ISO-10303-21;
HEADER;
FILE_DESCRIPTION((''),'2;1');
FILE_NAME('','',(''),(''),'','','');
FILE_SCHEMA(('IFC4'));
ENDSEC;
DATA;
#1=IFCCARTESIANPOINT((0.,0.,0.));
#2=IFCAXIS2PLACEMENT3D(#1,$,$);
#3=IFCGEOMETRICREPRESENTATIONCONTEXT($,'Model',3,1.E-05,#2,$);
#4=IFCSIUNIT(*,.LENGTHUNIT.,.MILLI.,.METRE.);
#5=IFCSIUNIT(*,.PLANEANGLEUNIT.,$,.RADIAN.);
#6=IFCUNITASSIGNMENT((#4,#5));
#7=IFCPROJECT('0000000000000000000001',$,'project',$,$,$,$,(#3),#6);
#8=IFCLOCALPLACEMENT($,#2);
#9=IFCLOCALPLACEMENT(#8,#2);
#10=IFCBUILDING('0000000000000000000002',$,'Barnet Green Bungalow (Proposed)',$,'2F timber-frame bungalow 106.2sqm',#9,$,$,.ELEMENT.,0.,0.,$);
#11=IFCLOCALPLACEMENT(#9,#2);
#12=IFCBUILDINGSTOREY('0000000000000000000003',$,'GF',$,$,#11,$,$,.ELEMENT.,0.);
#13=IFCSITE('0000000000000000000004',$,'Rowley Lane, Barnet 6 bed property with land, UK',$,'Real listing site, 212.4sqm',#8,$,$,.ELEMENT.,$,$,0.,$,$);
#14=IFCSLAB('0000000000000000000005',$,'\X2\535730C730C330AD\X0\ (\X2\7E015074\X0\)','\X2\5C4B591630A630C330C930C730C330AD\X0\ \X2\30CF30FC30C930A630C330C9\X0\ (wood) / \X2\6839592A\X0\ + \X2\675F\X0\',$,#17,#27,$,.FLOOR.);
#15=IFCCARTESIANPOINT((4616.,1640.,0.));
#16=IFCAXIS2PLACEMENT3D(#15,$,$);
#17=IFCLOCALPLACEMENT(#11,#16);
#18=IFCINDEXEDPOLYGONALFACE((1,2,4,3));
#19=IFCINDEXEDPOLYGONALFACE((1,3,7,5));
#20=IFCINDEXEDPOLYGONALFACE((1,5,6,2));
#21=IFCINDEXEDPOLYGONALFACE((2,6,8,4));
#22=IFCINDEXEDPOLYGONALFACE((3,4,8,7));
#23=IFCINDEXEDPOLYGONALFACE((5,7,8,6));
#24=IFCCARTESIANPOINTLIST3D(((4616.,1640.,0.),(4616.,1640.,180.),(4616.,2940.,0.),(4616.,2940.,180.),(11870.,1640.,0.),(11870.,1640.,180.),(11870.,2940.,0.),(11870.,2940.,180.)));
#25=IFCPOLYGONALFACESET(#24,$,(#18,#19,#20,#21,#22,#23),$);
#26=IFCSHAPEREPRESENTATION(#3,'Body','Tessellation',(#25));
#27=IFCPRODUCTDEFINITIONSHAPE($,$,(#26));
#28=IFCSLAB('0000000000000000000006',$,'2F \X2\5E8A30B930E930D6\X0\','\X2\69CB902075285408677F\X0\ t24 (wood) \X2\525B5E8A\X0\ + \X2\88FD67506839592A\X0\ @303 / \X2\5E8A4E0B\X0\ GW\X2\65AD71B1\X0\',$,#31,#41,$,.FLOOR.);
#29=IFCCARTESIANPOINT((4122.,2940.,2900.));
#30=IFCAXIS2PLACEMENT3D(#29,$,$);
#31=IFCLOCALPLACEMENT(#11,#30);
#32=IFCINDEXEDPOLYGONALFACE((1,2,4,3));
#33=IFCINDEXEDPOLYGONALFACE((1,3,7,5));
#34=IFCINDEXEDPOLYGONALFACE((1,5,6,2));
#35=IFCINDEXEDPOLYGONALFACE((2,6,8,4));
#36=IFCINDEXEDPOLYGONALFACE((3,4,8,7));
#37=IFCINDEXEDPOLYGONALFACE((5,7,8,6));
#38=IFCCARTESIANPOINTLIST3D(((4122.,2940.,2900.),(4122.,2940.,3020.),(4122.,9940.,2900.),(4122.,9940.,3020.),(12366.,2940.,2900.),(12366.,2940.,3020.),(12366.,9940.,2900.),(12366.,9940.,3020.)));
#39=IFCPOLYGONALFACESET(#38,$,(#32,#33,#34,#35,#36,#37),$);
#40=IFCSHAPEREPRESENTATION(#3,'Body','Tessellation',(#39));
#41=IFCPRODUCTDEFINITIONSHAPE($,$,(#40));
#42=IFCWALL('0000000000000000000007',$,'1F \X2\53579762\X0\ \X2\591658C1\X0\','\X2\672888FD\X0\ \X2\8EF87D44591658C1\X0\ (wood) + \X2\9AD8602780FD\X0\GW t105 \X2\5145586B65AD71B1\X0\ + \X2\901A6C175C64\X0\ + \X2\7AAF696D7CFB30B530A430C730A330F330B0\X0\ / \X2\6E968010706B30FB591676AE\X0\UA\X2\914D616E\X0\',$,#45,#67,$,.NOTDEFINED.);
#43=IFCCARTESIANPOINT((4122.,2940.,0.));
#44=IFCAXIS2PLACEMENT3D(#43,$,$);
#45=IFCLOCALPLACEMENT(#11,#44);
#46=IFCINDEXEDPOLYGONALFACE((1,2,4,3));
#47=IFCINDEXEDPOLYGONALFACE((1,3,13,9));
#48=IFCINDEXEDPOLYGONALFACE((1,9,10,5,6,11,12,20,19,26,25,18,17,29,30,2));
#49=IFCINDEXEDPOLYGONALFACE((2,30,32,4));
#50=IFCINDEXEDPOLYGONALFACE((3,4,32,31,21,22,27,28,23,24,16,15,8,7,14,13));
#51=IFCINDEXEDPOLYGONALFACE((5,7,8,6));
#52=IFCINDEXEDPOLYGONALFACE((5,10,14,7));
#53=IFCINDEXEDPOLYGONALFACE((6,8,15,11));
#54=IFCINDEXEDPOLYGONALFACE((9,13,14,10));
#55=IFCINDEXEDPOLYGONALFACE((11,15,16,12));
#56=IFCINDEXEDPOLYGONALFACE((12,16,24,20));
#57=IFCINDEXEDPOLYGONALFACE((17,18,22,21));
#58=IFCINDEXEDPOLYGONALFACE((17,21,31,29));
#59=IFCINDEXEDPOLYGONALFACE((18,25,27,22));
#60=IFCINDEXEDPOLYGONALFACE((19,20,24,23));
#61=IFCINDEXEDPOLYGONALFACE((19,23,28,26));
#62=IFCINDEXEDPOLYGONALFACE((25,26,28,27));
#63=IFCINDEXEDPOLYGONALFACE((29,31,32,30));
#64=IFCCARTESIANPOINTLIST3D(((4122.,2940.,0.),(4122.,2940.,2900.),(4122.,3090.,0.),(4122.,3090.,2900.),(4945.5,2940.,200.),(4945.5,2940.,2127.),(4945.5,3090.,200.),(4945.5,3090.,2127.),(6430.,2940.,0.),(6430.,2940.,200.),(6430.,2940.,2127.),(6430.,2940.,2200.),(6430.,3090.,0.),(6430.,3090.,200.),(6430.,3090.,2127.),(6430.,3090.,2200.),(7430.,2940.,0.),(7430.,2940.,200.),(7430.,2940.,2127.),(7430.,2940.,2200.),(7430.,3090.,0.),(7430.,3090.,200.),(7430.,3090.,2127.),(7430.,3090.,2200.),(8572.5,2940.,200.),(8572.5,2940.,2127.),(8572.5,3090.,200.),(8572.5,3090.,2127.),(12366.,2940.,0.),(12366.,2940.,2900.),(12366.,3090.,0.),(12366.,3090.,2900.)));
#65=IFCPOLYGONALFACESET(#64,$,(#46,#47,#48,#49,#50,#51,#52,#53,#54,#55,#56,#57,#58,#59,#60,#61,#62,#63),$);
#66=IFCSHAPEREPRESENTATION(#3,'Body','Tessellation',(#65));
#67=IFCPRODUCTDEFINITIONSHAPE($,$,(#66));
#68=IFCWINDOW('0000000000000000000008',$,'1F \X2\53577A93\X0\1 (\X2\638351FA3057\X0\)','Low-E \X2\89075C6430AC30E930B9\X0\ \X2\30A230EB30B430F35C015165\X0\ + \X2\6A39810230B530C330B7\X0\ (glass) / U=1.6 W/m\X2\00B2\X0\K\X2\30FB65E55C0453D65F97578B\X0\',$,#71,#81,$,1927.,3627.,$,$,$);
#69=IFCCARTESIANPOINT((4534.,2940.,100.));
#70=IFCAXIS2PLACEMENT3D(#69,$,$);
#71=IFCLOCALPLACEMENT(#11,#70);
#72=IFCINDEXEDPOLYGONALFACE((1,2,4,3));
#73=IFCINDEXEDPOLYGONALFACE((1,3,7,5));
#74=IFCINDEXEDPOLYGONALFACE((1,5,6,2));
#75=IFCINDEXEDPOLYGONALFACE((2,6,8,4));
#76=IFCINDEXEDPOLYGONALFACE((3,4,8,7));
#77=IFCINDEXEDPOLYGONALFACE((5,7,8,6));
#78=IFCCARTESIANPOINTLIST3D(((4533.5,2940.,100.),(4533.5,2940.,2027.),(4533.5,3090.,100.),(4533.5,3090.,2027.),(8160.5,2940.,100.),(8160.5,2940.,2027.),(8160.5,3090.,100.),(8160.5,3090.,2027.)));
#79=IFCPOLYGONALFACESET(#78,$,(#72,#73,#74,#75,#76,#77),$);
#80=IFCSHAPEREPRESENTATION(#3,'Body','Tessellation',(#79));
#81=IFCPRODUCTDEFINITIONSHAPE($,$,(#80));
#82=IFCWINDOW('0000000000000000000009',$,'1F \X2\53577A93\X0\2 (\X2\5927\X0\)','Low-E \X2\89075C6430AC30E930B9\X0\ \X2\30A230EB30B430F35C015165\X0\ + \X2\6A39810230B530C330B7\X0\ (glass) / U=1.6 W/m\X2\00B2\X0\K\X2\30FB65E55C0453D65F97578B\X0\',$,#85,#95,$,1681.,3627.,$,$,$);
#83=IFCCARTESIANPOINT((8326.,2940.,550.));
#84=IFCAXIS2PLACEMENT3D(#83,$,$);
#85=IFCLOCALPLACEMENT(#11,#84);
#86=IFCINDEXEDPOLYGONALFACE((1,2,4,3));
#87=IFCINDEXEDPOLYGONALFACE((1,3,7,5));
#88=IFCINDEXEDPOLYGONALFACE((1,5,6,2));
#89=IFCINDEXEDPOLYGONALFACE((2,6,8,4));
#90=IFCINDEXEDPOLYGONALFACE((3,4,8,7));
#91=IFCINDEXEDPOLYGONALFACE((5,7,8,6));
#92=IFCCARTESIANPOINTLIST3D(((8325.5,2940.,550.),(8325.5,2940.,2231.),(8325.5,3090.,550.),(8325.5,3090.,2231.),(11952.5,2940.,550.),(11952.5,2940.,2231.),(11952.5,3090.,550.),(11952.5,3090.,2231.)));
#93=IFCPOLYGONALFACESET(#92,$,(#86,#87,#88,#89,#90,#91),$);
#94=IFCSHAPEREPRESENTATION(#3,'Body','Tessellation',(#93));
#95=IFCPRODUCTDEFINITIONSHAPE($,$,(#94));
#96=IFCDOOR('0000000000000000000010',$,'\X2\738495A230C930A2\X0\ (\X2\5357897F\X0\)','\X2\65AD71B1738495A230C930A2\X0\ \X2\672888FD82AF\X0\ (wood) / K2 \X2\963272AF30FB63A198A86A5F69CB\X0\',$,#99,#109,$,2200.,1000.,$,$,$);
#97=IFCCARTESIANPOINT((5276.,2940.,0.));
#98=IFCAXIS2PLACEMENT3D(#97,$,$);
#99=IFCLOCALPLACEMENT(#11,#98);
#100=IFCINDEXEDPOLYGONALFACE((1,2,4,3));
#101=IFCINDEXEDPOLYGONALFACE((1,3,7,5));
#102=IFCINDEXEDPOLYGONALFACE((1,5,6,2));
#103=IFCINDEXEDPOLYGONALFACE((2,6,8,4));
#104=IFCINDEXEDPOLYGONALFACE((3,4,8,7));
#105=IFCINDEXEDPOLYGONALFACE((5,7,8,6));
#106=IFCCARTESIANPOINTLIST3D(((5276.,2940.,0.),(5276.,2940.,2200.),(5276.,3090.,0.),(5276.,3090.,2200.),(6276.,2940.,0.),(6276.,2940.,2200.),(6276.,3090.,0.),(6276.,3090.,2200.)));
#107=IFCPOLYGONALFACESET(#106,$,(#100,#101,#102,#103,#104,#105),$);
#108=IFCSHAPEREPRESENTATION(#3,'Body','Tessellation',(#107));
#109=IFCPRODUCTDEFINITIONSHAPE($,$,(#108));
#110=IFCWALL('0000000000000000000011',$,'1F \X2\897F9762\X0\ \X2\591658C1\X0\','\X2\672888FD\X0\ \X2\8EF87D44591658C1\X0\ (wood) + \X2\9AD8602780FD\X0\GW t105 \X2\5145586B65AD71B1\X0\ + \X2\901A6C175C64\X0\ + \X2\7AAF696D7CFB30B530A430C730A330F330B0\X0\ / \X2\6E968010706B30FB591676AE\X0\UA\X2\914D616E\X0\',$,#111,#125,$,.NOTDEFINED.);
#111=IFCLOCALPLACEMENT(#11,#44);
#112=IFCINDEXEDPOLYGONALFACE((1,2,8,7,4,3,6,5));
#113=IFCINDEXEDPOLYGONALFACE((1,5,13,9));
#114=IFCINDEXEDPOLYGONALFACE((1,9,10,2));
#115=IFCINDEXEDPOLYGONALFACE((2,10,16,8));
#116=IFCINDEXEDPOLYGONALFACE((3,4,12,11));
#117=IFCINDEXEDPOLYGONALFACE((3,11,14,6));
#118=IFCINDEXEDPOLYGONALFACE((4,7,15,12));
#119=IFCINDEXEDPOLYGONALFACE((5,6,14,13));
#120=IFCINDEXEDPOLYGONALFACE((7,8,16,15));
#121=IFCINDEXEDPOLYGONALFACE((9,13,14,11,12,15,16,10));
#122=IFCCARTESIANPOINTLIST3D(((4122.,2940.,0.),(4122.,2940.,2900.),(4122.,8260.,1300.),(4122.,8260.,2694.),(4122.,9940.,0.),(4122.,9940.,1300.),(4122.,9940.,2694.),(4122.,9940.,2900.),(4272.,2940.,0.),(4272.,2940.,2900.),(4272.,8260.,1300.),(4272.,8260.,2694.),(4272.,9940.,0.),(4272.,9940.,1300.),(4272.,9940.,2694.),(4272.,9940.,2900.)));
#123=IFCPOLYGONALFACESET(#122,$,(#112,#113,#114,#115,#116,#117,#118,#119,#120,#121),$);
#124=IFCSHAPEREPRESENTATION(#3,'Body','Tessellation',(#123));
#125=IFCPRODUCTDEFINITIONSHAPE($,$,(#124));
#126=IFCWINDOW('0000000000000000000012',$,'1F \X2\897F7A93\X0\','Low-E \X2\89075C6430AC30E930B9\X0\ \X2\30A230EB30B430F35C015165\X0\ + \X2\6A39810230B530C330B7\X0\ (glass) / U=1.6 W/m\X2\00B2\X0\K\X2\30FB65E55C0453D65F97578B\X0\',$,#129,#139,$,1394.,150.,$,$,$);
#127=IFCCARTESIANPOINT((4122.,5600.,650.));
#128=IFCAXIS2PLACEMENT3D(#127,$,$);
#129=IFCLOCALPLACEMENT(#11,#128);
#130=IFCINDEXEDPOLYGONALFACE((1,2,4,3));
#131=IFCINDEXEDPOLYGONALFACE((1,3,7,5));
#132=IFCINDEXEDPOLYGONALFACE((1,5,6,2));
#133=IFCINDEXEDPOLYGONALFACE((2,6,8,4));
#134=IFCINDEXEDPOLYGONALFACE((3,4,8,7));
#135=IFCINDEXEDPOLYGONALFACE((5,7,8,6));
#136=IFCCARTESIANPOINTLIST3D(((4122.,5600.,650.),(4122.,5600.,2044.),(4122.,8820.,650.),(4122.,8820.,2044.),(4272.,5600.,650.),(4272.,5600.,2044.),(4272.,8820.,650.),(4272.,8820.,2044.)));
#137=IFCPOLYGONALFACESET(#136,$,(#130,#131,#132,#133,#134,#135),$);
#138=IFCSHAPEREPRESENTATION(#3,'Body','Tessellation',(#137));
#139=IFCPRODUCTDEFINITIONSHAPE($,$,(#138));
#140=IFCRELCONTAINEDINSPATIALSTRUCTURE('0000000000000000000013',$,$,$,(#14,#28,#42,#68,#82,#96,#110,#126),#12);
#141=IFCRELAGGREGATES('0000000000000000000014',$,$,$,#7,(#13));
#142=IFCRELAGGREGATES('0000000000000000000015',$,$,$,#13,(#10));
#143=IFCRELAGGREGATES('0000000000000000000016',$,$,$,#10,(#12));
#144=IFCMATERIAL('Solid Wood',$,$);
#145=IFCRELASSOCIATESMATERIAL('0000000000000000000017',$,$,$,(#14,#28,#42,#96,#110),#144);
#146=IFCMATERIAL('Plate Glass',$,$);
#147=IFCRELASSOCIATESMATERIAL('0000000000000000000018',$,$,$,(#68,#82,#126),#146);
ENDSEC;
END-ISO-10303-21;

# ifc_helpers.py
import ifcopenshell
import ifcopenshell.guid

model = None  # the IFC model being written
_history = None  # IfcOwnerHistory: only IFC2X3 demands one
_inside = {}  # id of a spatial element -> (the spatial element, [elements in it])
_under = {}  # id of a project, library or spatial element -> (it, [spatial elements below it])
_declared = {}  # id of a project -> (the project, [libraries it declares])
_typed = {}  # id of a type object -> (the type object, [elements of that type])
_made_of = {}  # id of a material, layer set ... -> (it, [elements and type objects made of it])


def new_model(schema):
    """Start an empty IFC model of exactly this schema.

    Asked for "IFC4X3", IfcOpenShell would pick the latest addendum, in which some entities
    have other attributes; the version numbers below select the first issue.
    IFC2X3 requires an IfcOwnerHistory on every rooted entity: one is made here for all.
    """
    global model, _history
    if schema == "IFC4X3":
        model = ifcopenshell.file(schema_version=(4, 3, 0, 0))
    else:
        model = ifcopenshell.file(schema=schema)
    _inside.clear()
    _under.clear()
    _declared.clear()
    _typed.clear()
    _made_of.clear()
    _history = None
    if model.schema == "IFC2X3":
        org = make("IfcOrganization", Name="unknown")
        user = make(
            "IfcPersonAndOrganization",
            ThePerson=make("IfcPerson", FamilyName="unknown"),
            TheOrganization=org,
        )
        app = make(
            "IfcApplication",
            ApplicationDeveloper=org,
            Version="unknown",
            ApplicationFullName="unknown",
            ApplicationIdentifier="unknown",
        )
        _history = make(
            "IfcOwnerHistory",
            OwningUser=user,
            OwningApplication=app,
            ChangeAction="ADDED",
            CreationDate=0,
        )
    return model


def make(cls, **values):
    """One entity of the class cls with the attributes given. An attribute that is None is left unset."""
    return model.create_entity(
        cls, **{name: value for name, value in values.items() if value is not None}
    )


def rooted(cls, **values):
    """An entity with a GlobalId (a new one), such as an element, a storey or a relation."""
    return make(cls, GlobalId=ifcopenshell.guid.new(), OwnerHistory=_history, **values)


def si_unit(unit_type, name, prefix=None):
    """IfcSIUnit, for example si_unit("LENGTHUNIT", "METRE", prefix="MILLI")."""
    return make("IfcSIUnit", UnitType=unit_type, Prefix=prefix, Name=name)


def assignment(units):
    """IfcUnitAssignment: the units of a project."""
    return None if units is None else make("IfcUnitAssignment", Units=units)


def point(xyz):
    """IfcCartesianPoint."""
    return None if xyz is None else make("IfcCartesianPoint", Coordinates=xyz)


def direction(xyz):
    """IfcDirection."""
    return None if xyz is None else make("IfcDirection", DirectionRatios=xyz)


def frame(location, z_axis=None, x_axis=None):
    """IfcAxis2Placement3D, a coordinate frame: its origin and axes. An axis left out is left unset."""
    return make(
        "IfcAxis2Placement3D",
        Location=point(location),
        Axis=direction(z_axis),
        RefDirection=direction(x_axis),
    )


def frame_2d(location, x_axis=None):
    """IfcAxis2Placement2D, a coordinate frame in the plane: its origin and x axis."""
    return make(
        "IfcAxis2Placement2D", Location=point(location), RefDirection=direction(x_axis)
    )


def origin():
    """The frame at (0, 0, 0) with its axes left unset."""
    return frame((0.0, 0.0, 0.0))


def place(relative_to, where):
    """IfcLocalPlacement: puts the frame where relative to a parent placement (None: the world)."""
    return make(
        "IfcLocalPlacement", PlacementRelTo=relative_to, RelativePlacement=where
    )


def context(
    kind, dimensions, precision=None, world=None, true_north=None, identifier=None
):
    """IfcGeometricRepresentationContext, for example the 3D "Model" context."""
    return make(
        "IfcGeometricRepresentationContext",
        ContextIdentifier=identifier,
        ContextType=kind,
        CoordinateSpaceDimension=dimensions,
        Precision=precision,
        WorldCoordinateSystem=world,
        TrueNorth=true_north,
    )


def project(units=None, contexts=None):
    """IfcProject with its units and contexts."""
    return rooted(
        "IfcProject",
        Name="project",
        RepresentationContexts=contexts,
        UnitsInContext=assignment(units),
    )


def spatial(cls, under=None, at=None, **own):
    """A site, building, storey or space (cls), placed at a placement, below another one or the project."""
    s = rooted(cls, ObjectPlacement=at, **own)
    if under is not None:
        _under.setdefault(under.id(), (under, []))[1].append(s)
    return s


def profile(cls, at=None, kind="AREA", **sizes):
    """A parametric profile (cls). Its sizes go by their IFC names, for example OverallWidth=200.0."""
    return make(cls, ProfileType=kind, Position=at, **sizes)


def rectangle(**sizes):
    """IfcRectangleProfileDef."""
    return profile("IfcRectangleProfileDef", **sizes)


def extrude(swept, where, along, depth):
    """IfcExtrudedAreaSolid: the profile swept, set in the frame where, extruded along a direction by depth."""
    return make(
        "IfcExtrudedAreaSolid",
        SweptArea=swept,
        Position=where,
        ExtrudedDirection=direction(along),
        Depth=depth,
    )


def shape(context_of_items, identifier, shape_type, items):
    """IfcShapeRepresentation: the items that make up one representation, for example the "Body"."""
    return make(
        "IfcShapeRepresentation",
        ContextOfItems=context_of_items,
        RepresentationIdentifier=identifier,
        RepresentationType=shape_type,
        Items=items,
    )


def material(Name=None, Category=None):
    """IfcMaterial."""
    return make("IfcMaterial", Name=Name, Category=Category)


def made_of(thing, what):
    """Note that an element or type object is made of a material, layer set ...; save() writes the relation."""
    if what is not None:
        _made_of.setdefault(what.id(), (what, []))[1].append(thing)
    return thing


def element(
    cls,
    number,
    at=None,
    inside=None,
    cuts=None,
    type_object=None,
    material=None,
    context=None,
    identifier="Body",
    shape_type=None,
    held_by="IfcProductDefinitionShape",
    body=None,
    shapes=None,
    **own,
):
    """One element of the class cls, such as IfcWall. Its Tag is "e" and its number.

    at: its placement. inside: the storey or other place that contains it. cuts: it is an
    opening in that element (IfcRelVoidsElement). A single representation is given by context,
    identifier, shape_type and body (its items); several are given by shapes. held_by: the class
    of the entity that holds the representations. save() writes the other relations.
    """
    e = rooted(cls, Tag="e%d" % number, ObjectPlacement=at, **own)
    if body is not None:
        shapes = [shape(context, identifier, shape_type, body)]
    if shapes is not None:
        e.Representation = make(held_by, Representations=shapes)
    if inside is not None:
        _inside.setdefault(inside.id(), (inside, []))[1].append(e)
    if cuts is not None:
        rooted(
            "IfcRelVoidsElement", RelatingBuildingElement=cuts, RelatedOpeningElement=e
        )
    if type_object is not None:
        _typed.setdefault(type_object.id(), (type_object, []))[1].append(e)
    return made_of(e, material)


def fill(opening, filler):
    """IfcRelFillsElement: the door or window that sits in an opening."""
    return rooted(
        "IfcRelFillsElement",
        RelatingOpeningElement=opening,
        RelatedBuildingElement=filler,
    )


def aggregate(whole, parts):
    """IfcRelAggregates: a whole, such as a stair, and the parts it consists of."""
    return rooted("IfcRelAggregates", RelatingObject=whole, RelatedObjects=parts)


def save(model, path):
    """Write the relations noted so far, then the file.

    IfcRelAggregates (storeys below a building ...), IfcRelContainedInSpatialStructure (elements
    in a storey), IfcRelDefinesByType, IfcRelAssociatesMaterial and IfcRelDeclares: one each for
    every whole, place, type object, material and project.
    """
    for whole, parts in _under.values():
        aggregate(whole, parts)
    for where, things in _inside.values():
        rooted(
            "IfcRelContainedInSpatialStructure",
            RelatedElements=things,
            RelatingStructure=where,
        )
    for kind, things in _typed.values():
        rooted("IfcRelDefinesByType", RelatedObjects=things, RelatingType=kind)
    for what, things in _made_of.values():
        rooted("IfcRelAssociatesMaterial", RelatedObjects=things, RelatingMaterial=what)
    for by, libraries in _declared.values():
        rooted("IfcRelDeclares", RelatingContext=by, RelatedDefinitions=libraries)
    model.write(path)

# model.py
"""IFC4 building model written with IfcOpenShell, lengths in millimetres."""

from ifc_helpers import new_model, si_unit, frame, frame_2d, origin, place, context, project, spatial, rectangle, extrude, material, element, fill, save


model = new_model("IFC4")

# Units and contexts
model_context = context("Model", 3, precision=1e-05, world=origin())
ifc_project = project(units=[si_unit("LENGTHUNIT", "METRE", prefix="MILLI"), si_unit("PLANEANGLEUNIT", "RADIAN")], contexts=[model_context])

# Site, building, storey
site_placement = place(None, origin())
site = spatial("IfcSite", under=ifc_project, at=site_placement, Name="Rowley Lane, Barnet 6 bed property with land, UK", ObjectType="Real listing site, 212.4sqm", CompositionType="ELEMENT", RefElevation=0.0)
building_placement = place(site_placement, origin())
building = spatial("IfcBuilding", under=site, at=building_placement, Name="Barnet Green Bungalow (Proposed)", ObjectType="2F timber-frame bungalow 106.2sqm", CompositionType="ELEMENT", ElevationOfRefHeight=0.0, ElevationOfTerrain=0.0)
storey_placement = place(building_placement, origin())
storey = spatial("IfcBuildingStorey", under=building, at=storey_placement, Name="GF", CompositionType="ELEMENT", Elevation=0.0)

# Slabs
ifc_material_1 = material(Name="Solid Wood")
slab_1_placement = place(storey_placement, frame((4616.0, 1640.0, 0.0)))
element("IfcSlab", 1, at=slab_1_placement, inside=storey, material=ifc_material_1, Name="南デッキ (縁側)", Description="屋外ウッドデッキ ハードウッド (wood) / 根太 + 束", PredefinedType="FLOOR", context=model_context, shape_type="SweptSolid", body=[
    extrude(rectangle(XDim=7254.0, YDim=1300.0, at=frame_2d((3627.0, 650.0))), frame((4616.0, 1640.0, 0.0)), (0.0, 0.0, 1.0), 180.0),
])
slab_2_placement = place(storey_placement, frame((4122.0, 2940.0, 2900.0)))
element("IfcSlab", 2, at=slab_2_placement, inside=storey, material=ifc_material_1, Name="2F 床スラブ", Description="構造用合板 t24 (wood) 剛床 + 製材根太 @303 / 床下 GW断熱", PredefinedType="FLOOR", context=model_context, shape_type="SweptSolid", body=[
    extrude(rectangle(XDim=8244.0, YDim=7000.0, at=frame_2d((4122.0, 3500.0))), frame((4122.0, 2940.0, 2900.0)), (0.0, 0.0, 1.0), 120.0),
])

# Wall, openings, windows, door
wall_1_placement = place(storey_placement, frame((4122.0, 2940.0, 0.0)))
wall_1 = element("IfcWall", 3, at=wall_1_placement, inside=storey, material=ifc_material_1, Name="1F 南面 外壁", Description="木製 軸組外壁 (wood) + 高性能GW t105 充填断熱 + 通気層 + 窯業系サイディング / 準耐火・外皮UA配慮", PredefinedType="NOTDEFINED", context=model_context, shape_type="SweptSolid", body=[
    extrude(rectangle(XDim=8244.0, YDim=150.0, at=frame_2d((4122.0, 75.0))), frame((4122.0, 2940.0, 0.0)), (0.0, 0.0, 1.0), 2900.0),
])
opening_1_placement = place(storey_placement, frame((4534.0, 2940.0, 100.0)))
opening_1 = element("IfcOpeningElement", 4, at=opening_1_placement, cuts=wall_1, PredefinedType="NOTDEFINED", context=model_context, shape_type="SweptSolid", body=[
    extrude(rectangle(XDim=3627.0, YDim=150.0, at=frame_2d((1813.0, 75.0))), frame((4534.0, 2940.0, 100.0)), (0.0, 0.0, 1.0), 1927.0),
])
opening_2_placement = place(storey_placement, frame((8326.0, 2940.0, 550.0)))
opening_2 = element("IfcOpeningElement", 5, at=opening_2_placement, cuts=wall_1, PredefinedType="NOTDEFINED", context=model_context, shape_type="SweptSolid", body=[
    extrude(rectangle(XDim=3627.0, YDim=150.0, at=frame_2d((1813.0, 75.0))), frame((8326.0, 2940.0, 550.0)), (0.0, 0.0, 1.0), 1681.0),
])
opening_3_placement = place(storey_placement, frame((5276.0, 2940.0, 0.0)))
opening_3 = element("IfcOpeningElement", 6, at=opening_3_placement, cuts=wall_1, PredefinedType="NOTDEFINED", context=model_context, shape_type="SweptSolid", body=[
    extrude(rectangle(XDim=1000.0, YDim=150.0, at=frame_2d((500.0, 75.0))), frame((5276.0, 2940.0, 0.0)), (0.0, 0.0, 1.0), 2200.0),
])
ifc_material_2 = material(Name="Plate Glass")
window_1_placement = place(storey_placement, frame((4534.0, 2940.0, 100.0)))
window_1 = element("IfcWindow", 7, at=window_1_placement, inside=storey, material=ifc_material_2, Name="1F 南窓1 (掃出し)", Description="Low-E 複層ガラス アルゴン封入 + 樹脂サッシ (glass) / U=1.6 W/m²K・日射取得型", OverallHeight=1927.0, OverallWidth=3627.0, context=model_context, shape_type="SweptSolid", body=[
    extrude(rectangle(XDim=3627.0, YDim=150.0, at=frame_2d((1813.0, 75.0))), frame((4534.0, 2940.0, 100.0)), (0.0, 0.0, 1.0), 1927.0),
])
fill(opening_1, window_1)
window_2_placement = place(storey_placement, frame((8326.0, 2940.0, 550.0)))
window_2 = element("IfcWindow", 8, at=window_2_placement, inside=storey, material=ifc_material_2, Name="1F 南窓2 (大)", Description="Low-E 複層ガラス アルゴン封入 + 樹脂サッシ (glass) / U=1.6 W/m²K・日射取得型", OverallHeight=1681.0, OverallWidth=3627.0, context=model_context, shape_type="SweptSolid", body=[
    extrude(rectangle(XDim=3627.0, YDim=150.0, at=frame_2d((1813.0, 75.0))), frame((8326.0, 2940.0, 550.0)), (0.0, 0.0, 1.0), 1681.0),
])
fill(opening_2, window_2)
door_placement = place(storey_placement, frame((5276.0, 2940.0, 0.0)))
door = element("IfcDoor", 9, at=door_placement, inside=storey, material=ifc_material_1, Name="玄関ドア (南西)", Description="断熱玄関ドア 木製芯 (wood) / K2 防犯・採風機構", OverallHeight=2200.0, OverallWidth=1000.0, context=model_context, shape_type="SweptSolid", body=[
    extrude(rectangle(XDim=1000.0, YDim=150.0, at=frame_2d((500.0, 75.0))), frame((5276.0, 2940.0, 0.0)), (0.0, 0.0, 1.0), 2200.0),
])
fill(opening_3, door)

# Wall, opening, window
wall_2_placement = place(storey_placement, frame((4122.0, 2940.0, 0.0)))
wall_2 = element("IfcWall", 10, at=wall_2_placement, inside=storey, material=ifc_material_1, Name="1F 西面 外壁", Description="木製 軸組外壁 (wood) + 高性能GW t105 充填断熱 + 通気層 + 窯業系サイディング / 準耐火・外皮UA配慮", PredefinedType="NOTDEFINED", context=model_context, shape_type="SweptSolid", body=[
    extrude(rectangle(XDim=150.0, YDim=7000.0, at=frame_2d((75.0, 3500.0))), frame((4122.0, 2940.0, 0.0)), (0.0, 0.0, 1.0), 2900.0),
])
opening_4_placement = place(storey_placement, frame((4122.0, 5600.0, 650.0)))
opening_4 = element("IfcOpeningElement", 11, at=opening_4_placement, cuts=wall_2, PredefinedType="NOTDEFINED", context=model_context, shape_type="SweptSolid", body=[
    extrude(rectangle(XDim=150.0, YDim=3220.0, at=frame_2d((75.0, 1610.0))), frame((4122.0, 5600.0, 650.0)), (0.0, 0.0, 1.0), 1394.0),
])
window_3_placement = place(storey_placement, frame((4122.0, 5600.0, 650.0)))
window_3 = element("IfcWindow", 12, at=window_3_placement, inside=storey, material=ifc_material_2, Name="1F 西窓", Description="Low-E 複層ガラス アルゴン封入 + 樹脂サッシ (glass) / U=1.6 W/m²K・日射取得型", OverallHeight=1394.0, OverallWidth=150.0, context=model_context, shape_type="SweptSolid", body=[
    extrude(rectangle(XDim=150.0, YDim=3220.0, at=frame_2d((75.0, 1610.0))), frame((4122.0, 5600.0, 650.0)), (0.0, 0.0, 1.0), 1394.0),
])
fill(opening_4, window_3)

save(model, "model.ifc")
